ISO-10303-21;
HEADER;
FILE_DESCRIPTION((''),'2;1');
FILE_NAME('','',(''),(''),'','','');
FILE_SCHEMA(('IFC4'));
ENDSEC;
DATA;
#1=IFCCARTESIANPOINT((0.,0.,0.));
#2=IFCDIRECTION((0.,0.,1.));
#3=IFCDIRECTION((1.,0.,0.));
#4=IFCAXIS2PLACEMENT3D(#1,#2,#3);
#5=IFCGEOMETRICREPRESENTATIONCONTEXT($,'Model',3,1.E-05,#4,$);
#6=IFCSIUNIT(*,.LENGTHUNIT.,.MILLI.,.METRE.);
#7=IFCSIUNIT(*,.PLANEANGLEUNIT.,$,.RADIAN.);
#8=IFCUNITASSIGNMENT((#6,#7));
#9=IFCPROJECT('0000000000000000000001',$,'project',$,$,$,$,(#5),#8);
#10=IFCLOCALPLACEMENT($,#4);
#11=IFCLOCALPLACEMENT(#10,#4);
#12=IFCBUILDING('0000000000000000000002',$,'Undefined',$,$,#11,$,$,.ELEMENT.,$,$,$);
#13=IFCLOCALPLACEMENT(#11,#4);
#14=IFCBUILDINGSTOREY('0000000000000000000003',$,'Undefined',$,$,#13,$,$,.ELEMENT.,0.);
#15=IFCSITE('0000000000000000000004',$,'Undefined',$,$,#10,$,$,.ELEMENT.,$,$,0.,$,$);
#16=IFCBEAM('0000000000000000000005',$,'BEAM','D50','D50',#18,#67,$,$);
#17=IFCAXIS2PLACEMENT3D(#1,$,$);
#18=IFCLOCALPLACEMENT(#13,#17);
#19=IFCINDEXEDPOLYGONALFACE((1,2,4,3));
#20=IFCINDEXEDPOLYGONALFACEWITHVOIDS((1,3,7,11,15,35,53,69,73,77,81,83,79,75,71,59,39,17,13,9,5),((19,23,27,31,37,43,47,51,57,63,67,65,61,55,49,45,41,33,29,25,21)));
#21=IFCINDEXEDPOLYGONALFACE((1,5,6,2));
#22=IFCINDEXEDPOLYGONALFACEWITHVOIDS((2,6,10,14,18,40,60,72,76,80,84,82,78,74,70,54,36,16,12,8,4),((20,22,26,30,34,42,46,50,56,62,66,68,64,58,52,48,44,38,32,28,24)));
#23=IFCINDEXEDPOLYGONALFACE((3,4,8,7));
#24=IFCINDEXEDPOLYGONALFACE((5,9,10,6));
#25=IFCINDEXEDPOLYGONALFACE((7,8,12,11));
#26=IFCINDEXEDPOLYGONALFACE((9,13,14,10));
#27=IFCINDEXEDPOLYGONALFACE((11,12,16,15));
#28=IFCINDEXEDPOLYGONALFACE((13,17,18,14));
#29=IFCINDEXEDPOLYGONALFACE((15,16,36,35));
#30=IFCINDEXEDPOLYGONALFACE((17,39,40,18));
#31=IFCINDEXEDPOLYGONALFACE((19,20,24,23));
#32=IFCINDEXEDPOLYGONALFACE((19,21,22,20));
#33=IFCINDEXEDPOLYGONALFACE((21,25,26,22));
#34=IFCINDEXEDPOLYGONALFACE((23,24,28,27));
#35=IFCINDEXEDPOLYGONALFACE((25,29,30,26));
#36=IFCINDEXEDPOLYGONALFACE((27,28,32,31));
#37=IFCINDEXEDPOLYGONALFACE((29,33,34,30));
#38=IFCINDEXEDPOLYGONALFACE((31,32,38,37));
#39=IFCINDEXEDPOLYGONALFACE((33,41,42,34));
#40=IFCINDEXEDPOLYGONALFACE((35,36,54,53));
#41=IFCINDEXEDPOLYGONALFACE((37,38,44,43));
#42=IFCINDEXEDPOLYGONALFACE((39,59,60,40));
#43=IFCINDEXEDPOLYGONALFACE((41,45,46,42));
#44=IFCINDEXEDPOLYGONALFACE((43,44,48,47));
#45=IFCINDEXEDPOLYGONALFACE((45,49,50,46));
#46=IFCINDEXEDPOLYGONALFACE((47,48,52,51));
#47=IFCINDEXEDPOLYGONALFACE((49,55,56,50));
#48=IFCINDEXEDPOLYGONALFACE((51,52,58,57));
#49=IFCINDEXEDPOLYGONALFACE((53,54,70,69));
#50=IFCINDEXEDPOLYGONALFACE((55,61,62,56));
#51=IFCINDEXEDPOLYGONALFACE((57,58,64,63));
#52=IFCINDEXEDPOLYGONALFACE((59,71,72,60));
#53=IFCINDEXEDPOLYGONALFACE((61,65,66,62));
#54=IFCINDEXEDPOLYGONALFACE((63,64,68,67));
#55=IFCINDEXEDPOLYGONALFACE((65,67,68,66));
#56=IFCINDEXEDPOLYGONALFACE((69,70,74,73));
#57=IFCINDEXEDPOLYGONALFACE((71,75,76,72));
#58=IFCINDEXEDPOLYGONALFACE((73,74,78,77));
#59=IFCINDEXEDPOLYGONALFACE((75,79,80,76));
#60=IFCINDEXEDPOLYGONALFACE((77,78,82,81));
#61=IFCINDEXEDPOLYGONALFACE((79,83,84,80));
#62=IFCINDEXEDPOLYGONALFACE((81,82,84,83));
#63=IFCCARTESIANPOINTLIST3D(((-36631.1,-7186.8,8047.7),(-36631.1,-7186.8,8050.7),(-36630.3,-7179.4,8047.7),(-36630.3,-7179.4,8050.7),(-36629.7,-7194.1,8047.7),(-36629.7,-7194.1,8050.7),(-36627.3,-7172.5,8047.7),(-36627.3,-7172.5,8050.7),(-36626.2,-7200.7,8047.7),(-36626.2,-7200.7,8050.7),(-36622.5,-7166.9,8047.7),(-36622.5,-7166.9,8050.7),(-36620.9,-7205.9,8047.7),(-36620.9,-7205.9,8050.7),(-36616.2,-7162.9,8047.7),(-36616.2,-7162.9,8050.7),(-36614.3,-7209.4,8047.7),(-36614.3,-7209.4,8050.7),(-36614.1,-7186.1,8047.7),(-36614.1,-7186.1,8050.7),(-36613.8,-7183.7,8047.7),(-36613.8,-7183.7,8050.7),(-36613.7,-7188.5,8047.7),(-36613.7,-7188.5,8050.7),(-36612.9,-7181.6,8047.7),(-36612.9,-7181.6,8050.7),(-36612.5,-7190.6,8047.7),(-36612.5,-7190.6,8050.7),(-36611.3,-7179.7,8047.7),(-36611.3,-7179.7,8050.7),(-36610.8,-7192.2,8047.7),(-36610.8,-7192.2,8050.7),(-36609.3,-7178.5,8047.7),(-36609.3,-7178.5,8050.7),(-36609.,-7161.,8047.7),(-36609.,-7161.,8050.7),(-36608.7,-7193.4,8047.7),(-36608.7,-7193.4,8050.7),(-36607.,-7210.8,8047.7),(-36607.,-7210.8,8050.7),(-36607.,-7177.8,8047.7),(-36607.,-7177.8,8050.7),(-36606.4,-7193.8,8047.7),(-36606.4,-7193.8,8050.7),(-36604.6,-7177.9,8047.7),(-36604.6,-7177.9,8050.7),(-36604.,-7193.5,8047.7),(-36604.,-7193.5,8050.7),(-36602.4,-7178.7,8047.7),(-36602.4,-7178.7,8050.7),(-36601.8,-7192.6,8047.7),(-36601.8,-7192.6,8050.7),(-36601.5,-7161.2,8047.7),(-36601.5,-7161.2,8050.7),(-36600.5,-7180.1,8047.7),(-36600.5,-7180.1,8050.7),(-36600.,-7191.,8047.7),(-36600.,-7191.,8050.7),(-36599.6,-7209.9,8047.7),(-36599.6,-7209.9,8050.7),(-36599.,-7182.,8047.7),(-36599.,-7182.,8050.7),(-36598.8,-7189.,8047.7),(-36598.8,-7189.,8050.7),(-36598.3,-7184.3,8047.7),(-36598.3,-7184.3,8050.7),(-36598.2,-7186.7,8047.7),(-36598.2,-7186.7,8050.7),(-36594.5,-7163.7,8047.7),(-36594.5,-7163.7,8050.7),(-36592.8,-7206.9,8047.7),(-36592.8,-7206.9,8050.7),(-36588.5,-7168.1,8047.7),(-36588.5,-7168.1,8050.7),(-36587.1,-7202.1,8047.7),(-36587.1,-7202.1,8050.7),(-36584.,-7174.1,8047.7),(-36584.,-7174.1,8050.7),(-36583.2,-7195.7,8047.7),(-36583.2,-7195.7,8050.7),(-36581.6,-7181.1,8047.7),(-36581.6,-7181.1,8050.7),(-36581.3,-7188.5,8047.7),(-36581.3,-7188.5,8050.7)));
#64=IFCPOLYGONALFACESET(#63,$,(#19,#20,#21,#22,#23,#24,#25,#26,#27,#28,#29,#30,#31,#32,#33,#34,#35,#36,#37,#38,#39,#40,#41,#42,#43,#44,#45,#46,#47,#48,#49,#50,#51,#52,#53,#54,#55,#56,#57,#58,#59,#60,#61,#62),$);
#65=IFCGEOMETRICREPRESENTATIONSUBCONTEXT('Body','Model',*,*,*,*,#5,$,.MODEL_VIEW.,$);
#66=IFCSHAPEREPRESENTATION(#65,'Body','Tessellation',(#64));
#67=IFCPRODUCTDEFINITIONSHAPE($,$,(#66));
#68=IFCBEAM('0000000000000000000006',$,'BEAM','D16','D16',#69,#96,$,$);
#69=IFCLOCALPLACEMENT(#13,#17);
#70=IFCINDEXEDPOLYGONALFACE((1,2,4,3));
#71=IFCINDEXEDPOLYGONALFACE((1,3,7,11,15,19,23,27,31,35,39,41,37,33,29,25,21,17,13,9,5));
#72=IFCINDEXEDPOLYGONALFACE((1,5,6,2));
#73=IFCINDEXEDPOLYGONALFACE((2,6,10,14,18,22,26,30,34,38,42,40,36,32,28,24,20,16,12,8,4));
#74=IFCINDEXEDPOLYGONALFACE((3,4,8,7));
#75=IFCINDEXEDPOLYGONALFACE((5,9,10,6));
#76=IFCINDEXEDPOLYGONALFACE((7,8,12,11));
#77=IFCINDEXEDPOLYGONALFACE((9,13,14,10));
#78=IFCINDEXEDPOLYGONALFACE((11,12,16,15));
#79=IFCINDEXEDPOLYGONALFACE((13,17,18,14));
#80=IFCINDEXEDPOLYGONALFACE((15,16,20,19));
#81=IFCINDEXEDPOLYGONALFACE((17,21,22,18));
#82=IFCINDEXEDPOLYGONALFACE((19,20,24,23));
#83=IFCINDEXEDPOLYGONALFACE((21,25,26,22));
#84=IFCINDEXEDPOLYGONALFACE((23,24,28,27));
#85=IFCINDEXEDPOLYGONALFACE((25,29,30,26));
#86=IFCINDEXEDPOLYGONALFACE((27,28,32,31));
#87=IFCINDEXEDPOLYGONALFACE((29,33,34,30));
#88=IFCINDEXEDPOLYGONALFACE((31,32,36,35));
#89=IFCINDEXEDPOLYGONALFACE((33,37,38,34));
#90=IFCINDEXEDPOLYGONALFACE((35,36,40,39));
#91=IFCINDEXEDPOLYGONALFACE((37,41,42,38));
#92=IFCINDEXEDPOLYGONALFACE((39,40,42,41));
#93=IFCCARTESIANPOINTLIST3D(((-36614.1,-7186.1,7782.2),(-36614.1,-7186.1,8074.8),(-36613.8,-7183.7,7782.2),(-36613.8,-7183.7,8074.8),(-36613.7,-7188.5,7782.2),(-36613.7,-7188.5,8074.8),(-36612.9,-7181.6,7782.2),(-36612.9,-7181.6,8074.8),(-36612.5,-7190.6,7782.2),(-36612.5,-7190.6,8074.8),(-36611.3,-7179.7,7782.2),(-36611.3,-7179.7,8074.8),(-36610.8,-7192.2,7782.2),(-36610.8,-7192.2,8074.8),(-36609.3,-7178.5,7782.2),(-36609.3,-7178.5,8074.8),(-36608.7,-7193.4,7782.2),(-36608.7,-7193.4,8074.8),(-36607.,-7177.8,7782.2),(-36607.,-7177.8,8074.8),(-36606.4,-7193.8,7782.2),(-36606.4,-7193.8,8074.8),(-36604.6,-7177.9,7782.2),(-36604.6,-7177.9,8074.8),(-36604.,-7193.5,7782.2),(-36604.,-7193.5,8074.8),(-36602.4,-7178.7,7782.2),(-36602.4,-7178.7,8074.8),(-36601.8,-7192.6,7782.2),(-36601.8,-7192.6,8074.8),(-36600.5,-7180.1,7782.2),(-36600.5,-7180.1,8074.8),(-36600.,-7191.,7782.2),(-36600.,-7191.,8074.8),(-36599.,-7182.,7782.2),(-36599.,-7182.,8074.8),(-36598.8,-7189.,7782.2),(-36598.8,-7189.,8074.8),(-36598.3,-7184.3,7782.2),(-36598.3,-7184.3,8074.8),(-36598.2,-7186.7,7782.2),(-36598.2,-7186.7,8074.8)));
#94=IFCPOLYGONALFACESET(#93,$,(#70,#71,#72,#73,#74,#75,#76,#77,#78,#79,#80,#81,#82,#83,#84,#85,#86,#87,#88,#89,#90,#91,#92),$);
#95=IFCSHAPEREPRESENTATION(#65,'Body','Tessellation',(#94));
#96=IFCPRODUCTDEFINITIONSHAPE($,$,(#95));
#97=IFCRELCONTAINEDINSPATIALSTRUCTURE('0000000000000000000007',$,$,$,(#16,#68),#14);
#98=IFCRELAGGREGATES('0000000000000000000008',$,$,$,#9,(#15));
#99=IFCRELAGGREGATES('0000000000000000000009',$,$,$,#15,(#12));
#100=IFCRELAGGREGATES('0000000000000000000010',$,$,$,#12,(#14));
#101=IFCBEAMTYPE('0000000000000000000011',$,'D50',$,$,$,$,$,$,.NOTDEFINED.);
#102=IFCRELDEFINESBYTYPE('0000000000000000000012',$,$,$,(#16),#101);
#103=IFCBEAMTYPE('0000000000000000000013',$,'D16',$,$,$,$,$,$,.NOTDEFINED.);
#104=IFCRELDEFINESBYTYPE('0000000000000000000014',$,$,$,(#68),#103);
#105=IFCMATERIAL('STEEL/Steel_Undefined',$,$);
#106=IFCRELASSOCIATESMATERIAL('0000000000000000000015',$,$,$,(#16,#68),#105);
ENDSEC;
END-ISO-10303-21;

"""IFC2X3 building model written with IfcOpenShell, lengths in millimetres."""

from ifc_helpers import new_model, si_unit, frame, origin_with_axes, origin_2d_with_axis, place, context, subcontext, project, spatial, circle, extrude, material, type_object, element, save


model = new_model("IFC2X3")

# Units and contexts
model_context = context("Model", 3, precision=1e-05, world=origin_with_axes())
body_context = subcontext(model_context, "Body", "Model", "MODEL_VIEW")
ifc_project = project(units=[si_unit("LENGTHUNIT", "METRE", prefix="MILLI"), si_unit("PLANEANGLEUNIT", "RADIAN")], contexts=[model_context])

# Site, building, storey
site_placement = place(None, origin_with_axes())
site = spatial("IfcSite", under=ifc_project, at=site_placement, Name="Undefined", CompositionType="ELEMENT", RefElevation=0.0)
building_placement = place(site_placement, origin_with_axes())
building = spatial("IfcBuilding", under=site, at=building_placement, Name="Undefined", CompositionType="ELEMENT")
storey_placement = place(building_placement, origin_with_axes())
storey = spatial("IfcBuildingStorey", under=building, at=storey_placement, Name="Undefined", CompositionType="ELEMENT", Elevation=0.0)

# Shared definitions
ifc_material = material(Name="STEEL/Steel_Undefined")

# Beam, opening
beam_type_1 = type_object("IfcBeamType", Name="D50", PredefinedType="NOTDEFINED")
beam_1_placement = place(storey_placement, frame((-36606.1, -7185.8, 8050.7), z_axis=(-0.915553, -0.402198, 0.0), x_axis=(0.0, 0.0, -1.0)))
beam_1 = element("IfcBeam", 1, at=beam_1_placement, inside=storey, type_object=beam_type_1, material=ifc_material, Name="BEAM", Description="D50", ObjectType="D50", context=body_context, shape_type="SweptSolid", body=[
    extrude(circle(Radius=25.0, at=origin_2d_with_axis()), frame((3.0, 0.0, 0.0), z_axis=(-1.0, 0.0, 0.0), x_axis=(0.0, -1.0, 0.0)), (0.0, 0.0, 1.0), 3.0),
])
opening_1_placement = place(storey_placement, frame((-36606.1, -7185.8, 8050.7), z_axis=(-0.915553, -0.402198, 0.0), x_axis=(0.0, 0.0, -1.0)))
element("IfcOpeningElement", 2, at=opening_1_placement, cuts=beam_1, ObjectType="Recess", context=body_context, shape_type="SweptSolid", body=[
    extrude(circle(Radius=8.0, at=origin_2d_with_axis()), frame((268.5, 0.0, 0.0), z_axis=(-1.0, 0.0, 0.0), x_axis=(0.0, -1.0, 0.0)), (0.0, 0.0, 1.0), 292.6),
])

# Beam
beam_type_2 = type_object("IfcBeamType", Name="D16", PredefinedType="NOTDEFINED")
beam_2_placement = place(storey_placement, frame((-36606.1, -7185.8, 8074.8), z_axis=(-0.915553, -0.402198, 0.0), x_axis=(0.0, 0.0, -1.0)))
element("IfcBeam", 3, at=beam_2_placement, inside=storey, type_object=beam_type_2, material=ifc_material, Name="BEAM", Description="D16", ObjectType="D16", context=body_context, shape_type="SweptSolid", body=[
    extrude(circle(Radius=8.0, at=origin_2d_with_axis()), frame((292.6, 0.0, 0.0), z_axis=(-1.0, 0.0, 0.0), x_axis=(0.0, -1.0, 0.0)), (0.0, 0.0, 1.0), 292.6),
])

save(model, "model.ifc")
